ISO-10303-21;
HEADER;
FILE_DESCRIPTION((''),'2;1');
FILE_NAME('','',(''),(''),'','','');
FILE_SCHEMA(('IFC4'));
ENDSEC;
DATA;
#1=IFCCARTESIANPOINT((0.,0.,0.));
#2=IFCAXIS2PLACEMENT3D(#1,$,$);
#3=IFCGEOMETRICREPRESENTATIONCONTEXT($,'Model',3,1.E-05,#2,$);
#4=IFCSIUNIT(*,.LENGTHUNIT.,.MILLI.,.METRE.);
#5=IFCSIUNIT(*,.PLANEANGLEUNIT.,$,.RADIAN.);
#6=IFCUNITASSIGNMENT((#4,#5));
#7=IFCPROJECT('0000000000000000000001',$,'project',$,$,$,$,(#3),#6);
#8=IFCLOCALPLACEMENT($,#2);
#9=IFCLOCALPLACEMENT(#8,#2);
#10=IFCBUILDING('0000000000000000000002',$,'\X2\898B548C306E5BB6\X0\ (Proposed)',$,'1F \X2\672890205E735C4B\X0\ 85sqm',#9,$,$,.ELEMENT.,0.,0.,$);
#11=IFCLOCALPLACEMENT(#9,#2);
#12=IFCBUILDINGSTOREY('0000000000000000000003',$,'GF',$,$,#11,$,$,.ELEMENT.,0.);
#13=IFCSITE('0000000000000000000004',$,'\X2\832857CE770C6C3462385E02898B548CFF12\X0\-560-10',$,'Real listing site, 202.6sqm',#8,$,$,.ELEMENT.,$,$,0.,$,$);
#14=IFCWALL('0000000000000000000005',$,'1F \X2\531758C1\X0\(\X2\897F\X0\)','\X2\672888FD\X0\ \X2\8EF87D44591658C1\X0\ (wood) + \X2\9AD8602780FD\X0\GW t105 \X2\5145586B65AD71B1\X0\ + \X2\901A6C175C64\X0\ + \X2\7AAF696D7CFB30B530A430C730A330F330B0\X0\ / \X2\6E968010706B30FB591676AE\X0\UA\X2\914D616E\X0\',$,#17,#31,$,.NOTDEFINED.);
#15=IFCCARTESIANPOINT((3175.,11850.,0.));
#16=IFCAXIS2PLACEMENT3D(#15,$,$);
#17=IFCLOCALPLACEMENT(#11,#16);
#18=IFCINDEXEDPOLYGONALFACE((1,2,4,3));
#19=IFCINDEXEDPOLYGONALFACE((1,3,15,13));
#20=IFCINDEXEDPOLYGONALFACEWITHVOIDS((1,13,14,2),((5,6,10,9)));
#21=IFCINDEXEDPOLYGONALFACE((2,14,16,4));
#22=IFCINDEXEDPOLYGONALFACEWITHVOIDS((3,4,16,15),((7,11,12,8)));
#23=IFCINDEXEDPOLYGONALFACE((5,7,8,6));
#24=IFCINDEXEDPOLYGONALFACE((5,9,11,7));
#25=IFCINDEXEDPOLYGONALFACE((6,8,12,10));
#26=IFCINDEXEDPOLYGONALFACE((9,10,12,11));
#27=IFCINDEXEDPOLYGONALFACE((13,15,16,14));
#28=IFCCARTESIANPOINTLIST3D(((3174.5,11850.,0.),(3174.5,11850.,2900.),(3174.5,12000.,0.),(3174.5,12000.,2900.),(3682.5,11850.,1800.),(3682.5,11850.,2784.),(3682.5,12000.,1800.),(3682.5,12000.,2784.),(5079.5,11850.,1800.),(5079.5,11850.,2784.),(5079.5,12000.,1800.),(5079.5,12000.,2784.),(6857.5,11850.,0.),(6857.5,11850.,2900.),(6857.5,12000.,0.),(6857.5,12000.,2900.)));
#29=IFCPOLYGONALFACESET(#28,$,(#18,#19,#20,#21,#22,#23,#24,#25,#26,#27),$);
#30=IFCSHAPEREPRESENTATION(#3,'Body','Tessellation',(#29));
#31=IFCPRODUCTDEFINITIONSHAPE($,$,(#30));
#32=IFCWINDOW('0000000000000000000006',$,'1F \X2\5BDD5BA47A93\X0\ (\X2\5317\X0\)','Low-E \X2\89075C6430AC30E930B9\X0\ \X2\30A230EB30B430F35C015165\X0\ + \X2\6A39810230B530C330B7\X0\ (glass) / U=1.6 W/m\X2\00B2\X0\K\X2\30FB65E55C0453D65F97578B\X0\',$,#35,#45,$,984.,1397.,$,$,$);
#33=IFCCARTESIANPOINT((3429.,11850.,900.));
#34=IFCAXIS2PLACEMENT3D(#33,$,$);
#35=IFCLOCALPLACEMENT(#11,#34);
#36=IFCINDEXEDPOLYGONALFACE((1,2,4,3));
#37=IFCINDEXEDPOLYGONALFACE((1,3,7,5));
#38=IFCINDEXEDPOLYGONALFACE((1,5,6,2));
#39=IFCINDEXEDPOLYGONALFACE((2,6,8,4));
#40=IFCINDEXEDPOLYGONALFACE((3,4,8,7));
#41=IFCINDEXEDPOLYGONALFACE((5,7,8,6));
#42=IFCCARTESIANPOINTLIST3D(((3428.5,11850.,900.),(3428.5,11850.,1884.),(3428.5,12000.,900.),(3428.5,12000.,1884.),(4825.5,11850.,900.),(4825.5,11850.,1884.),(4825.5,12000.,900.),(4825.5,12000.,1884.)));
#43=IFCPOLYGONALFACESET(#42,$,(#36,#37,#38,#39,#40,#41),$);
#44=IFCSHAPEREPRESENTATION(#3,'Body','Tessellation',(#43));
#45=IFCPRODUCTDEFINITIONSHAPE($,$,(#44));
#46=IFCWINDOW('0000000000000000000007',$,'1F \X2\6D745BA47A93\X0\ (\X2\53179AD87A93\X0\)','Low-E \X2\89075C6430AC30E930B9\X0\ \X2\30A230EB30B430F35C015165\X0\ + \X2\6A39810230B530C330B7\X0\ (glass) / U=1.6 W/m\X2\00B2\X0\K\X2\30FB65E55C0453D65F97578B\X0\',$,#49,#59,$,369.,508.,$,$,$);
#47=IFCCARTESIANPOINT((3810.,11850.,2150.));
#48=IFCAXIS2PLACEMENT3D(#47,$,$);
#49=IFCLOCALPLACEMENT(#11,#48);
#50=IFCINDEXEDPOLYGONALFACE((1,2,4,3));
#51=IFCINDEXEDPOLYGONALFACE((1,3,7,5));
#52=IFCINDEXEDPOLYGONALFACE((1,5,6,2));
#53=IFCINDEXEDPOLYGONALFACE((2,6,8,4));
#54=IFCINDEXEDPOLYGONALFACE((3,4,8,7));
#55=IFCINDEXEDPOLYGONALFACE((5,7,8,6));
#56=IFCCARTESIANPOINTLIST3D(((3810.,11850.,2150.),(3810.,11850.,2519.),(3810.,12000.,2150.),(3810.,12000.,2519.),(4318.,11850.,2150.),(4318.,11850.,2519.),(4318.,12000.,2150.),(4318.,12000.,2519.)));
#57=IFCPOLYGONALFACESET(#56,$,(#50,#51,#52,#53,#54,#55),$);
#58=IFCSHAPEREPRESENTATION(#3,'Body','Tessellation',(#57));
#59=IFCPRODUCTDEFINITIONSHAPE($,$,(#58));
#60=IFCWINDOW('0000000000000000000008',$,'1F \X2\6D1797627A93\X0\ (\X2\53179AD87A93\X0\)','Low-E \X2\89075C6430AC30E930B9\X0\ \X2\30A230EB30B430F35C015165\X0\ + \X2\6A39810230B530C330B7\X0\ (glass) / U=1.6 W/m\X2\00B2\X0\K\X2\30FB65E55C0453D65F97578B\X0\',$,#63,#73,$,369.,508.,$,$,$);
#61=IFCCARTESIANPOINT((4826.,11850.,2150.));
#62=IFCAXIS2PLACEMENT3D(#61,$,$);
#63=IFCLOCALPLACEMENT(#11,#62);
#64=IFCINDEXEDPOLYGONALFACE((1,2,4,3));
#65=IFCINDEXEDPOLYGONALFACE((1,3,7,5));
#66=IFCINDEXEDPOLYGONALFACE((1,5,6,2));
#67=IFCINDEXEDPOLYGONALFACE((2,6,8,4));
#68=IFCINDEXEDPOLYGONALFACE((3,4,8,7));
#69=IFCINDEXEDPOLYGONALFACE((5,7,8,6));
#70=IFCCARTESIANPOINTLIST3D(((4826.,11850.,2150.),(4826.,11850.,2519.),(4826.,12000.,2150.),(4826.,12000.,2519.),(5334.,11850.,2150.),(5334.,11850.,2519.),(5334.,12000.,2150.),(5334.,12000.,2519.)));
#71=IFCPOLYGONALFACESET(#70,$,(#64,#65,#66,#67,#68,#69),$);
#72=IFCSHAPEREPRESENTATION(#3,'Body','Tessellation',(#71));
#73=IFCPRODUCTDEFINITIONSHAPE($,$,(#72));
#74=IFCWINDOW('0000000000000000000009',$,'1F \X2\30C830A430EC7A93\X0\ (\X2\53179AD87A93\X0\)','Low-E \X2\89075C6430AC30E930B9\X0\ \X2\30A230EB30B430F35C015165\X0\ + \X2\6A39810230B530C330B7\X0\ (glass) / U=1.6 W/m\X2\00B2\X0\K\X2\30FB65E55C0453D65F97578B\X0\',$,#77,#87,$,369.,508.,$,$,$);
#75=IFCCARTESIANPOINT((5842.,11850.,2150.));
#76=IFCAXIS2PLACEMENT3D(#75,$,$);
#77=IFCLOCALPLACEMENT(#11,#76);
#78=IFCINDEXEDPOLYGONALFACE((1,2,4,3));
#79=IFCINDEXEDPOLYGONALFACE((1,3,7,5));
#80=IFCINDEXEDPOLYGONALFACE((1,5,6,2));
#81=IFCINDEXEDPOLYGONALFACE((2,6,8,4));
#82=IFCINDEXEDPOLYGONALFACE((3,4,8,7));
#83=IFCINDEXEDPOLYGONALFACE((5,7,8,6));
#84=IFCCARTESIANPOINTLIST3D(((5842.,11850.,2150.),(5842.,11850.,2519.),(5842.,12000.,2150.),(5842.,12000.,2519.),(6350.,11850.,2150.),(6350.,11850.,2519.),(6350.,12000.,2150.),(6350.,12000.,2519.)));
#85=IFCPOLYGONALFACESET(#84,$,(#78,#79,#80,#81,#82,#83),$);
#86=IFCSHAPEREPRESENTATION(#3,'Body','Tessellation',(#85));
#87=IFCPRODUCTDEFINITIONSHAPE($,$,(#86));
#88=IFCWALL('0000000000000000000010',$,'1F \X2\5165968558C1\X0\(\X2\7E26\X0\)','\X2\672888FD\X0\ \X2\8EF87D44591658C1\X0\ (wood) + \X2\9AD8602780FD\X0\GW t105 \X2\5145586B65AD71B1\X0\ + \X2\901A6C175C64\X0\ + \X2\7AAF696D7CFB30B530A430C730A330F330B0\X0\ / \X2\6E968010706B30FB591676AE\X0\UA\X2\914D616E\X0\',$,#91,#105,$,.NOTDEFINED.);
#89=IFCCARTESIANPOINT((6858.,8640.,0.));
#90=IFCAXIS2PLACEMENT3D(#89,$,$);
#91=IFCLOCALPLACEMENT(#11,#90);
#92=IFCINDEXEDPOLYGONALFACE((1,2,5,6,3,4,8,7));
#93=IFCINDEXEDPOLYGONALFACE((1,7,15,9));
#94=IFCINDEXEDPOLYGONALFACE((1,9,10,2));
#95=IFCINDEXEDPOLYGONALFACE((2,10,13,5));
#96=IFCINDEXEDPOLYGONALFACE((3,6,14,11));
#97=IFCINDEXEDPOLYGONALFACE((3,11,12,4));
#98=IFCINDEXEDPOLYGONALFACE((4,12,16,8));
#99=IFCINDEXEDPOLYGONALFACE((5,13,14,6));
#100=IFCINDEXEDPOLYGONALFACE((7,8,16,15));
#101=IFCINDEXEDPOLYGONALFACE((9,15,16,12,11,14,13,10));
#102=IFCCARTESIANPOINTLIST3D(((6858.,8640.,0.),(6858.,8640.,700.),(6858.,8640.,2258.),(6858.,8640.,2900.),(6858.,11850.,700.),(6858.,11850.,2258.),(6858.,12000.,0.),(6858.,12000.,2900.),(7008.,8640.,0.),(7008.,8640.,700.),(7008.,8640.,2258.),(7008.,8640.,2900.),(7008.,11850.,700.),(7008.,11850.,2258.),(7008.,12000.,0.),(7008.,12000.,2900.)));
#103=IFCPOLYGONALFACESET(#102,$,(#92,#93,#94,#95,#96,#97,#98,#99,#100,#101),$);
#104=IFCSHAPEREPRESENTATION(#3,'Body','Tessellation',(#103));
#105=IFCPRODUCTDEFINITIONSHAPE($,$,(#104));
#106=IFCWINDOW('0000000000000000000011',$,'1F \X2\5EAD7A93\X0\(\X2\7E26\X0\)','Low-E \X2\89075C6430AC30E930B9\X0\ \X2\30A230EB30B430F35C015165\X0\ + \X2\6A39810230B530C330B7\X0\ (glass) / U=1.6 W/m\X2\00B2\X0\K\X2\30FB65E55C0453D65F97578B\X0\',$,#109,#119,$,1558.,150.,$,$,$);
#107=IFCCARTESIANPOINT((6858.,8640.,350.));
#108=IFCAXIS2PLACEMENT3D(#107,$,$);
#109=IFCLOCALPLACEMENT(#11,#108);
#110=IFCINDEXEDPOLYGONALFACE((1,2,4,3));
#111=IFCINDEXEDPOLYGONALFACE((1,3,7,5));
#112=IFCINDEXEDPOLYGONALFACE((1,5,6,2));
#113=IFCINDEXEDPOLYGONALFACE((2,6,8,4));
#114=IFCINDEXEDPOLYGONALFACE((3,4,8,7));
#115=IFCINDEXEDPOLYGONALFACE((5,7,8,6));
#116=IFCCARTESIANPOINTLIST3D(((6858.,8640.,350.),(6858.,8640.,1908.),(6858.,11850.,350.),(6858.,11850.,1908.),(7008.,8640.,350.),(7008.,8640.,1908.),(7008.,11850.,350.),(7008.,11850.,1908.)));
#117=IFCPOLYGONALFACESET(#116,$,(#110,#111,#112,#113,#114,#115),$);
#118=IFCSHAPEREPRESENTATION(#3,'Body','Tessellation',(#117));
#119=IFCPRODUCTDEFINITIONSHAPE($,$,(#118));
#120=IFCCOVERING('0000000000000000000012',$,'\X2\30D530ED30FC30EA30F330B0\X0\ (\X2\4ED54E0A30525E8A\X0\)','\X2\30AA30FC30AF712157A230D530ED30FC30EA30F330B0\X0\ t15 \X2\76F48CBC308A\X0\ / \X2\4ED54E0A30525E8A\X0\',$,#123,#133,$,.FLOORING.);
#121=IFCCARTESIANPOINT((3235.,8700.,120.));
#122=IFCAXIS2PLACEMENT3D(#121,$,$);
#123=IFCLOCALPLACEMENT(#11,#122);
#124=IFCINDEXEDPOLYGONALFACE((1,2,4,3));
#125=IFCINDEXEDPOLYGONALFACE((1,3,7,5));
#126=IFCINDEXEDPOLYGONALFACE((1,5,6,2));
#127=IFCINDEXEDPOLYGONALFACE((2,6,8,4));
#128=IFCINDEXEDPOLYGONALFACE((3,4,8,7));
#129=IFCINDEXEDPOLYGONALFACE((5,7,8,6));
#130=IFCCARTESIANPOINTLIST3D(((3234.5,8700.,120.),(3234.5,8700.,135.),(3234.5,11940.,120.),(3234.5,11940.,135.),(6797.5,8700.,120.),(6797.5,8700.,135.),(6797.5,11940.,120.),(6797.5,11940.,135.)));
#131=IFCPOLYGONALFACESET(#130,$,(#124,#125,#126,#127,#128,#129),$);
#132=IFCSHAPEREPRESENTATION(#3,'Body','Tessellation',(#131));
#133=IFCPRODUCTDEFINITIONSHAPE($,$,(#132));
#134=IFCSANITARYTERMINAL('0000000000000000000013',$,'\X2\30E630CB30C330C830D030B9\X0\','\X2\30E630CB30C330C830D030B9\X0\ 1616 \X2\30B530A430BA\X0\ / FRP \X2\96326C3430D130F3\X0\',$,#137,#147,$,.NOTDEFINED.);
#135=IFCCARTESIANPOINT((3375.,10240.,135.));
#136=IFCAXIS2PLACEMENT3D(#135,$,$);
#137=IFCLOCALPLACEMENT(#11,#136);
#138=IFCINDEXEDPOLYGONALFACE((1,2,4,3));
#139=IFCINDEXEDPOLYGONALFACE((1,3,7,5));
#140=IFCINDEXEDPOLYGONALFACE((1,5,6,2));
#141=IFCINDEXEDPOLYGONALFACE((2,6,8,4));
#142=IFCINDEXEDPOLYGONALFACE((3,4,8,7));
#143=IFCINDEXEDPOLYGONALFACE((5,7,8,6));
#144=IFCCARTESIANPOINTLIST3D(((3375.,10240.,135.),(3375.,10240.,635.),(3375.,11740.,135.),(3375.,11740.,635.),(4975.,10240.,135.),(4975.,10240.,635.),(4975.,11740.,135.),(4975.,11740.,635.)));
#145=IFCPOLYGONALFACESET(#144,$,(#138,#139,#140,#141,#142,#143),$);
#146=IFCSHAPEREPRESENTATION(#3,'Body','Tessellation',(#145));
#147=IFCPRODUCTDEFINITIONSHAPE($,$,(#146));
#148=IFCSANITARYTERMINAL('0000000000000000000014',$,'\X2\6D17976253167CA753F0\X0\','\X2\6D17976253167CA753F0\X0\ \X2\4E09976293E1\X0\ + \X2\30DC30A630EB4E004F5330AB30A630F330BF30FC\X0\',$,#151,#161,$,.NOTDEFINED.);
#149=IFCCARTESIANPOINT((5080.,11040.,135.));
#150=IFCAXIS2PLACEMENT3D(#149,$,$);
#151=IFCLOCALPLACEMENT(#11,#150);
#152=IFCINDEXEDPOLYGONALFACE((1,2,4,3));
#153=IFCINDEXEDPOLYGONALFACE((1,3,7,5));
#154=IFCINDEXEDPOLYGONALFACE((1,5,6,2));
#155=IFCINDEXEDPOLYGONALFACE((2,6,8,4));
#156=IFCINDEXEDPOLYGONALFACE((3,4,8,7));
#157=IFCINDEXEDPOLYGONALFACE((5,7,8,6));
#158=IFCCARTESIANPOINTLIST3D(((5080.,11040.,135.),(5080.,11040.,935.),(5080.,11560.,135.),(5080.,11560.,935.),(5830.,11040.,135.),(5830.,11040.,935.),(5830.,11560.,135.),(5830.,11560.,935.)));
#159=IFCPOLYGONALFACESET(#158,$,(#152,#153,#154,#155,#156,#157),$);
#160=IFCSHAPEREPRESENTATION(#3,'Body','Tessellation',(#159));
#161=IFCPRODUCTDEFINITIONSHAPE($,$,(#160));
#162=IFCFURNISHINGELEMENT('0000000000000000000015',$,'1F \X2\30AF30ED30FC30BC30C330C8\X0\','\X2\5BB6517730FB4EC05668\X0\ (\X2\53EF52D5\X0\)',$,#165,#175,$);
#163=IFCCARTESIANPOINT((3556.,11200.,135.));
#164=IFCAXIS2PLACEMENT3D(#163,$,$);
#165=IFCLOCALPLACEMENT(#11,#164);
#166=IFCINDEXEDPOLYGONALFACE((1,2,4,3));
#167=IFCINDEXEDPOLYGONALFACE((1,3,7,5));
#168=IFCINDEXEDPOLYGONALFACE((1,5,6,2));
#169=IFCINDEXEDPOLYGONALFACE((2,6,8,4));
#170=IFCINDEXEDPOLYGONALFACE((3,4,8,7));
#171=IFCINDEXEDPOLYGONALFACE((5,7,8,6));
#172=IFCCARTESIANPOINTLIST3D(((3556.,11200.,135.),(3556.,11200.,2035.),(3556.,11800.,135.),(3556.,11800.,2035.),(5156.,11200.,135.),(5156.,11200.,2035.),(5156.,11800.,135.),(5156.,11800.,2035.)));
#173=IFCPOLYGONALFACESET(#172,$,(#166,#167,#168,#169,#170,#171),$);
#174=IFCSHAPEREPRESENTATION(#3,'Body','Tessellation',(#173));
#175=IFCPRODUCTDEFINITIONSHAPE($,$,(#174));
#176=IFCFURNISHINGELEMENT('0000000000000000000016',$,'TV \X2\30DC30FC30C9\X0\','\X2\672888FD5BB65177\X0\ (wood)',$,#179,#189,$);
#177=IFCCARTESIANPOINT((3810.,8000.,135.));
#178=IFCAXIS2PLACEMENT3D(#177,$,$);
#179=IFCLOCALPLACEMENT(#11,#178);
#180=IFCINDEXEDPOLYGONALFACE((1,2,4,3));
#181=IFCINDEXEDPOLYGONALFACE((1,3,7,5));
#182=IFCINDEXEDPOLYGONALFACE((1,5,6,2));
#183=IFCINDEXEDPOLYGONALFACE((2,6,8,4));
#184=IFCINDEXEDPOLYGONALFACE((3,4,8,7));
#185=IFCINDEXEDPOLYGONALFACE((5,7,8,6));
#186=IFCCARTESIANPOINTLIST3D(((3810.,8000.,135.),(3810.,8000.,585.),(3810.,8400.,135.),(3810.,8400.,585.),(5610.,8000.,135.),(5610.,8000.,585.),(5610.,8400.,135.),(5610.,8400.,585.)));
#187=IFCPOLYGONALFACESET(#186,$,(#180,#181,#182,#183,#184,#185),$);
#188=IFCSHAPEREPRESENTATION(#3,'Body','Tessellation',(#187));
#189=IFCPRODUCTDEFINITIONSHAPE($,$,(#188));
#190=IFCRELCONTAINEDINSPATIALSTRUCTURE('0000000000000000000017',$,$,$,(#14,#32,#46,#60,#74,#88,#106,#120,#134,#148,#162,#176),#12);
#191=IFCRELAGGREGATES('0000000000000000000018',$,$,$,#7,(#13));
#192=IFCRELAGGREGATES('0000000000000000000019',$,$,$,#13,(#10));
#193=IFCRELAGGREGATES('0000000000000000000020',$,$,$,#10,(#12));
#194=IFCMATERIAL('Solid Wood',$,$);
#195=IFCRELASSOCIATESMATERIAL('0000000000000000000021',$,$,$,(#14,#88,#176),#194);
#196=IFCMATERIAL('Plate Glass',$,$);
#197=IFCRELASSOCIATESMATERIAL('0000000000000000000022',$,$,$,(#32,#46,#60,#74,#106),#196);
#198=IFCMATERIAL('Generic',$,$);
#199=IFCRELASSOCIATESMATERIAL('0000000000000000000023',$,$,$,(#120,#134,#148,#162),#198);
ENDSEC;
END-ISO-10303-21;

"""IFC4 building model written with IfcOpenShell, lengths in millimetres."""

from ifc_helpers import new_model, si_unit, frame, frame_2d, origin, place, context, project, spatial, rectangle, extrude, material, element, fill, save


model = new_model("IFC4")

# Units and contexts
model_context = context("Model", 3, precision=1e-05, world=origin())
ifc_project = project(units=[si_unit("LENGTHUNIT", "METRE", prefix="MILLI"), si_unit("PLANEANGLEUNIT", "RADIAN")], contexts=[model_context])

# Site, building, storey
site_placement = place(None, origin())
site = spatial("IfcSite", under=ifc_project, at=site_placement, Name="茨城県水戸市見和２-560-10", ObjectType="Real listing site, 202.6sqm", CompositionType="ELEMENT", RefElevation=0.0)
building_placement = place(site_placement, origin())
building = spatial("IfcBuilding", under=site, at=building_placement, Name="見和の家 (Proposed)", ObjectType="1F 木造平屋 85sqm", CompositionType="ELEMENT", ElevationOfRefHeight=0.0, ElevationOfTerrain=0.0)
storey_placement = place(building_placement, origin())
storey = spatial("IfcBuildingStorey", under=building, at=storey_placement, Name="GF", CompositionType="ELEMENT", Elevation=0.0)

# Shared definitions
ifc_material_1 = material(Name="Solid Wood")

# Wall, openings, windows
wall_1_placement = place(storey_placement, frame((3175.0, 11850.0, 0.0)))
wall_1 = element("IfcWall", 1, at=wall_1_placement, inside=storey, material=ifc_material_1, Name="1F 北壁(西)", Description="木製 軸組外壁 (wood) + 高性能GW t105 充填断熱 + 通気層 + 窯業系サイディング / 準耐火・外皮UA配慮", PredefinedType="NOTDEFINED", context=model_context, shape_type="SweptSolid", body=[
    extrude(rectangle(XDim=3683.0, YDim=150.0, at=frame_2d((1841.0, 75.0))), frame((3175.0, 11850.0, 0.0)), (0.0, 0.0, 1.0), 2900.0),
])
opening_1_placement = place(storey_placement, frame((3429.0, 11850.0, 900.0)))
opening_1 = element("IfcOpeningElement", 2, at=opening_1_placement, cuts=wall_1, PredefinedType="NOTDEFINED", context=model_context, shape_type="SweptSolid", body=[
    extrude(rectangle(XDim=1397.0, YDim=150.0, at=frame_2d((698.0, 75.0))), frame((3429.0, 11850.0, 900.0)), (0.0, 0.0, 1.0), 984.0),
])
opening_2_placement = place(storey_placement, frame((3810.0, 11850.0, 2150.0)))
opening_2 = element("IfcOpeningElement", 3, at=opening_2_placement, cuts=wall_1, PredefinedType="NOTDEFINED", context=model_context, shape_type="SweptSolid", body=[
    extrude(rectangle(XDim=508.0, YDim=150.0, at=frame_2d((254.0, 75.0))), frame((3810.0, 11850.0, 2150.0)), (0.0, 0.0, 1.0), 369.0),
])
opening_3_placement = place(storey_placement, frame((4826.0, 11850.0, 2150.0)))
opening_3 = element("IfcOpeningElement", 4, at=opening_3_placement, cuts=wall_1, PredefinedType="NOTDEFINED", context=model_context, shape_type="SweptSolid", body=[
    extrude(rectangle(XDim=508.0, YDim=150.0, at=frame_2d((254.0, 75.0))), frame((4826.0, 11850.0, 2150.0)), (0.0, 0.0, 1.0), 369.0),
])
opening_4_placement = place(storey_placement, frame((5842.0, 11850.0, 2150.0)))
opening_4 = element("IfcOpeningElement", 5, at=opening_4_placement, cuts=wall_1, PredefinedType="NOTDEFINED", context=model_context, shape_type="SweptSolid", body=[
    extrude(rectangle(XDim=508.0, YDim=150.0, at=frame_2d((254.0, 75.0))), frame((5842.0, 11850.0, 2150.0)), (0.0, 0.0, 1.0), 369.0),
])
ifc_material_2 = material(Name="Plate Glass")
window_1_placement = place(storey_placement, frame((3429.0, 11850.0, 900.0)))
window_1 = element("IfcWindow", 6, at=window_1_placement, inside=storey, material=ifc_material_2, Name="1F 寝室窓 (北)", Description="Low-E 複層ガラス アルゴン封入 + 樹脂サッシ (glass) / U=1.6 W/m²K・日射取得型", OverallHeight=984.0, OverallWidth=1397.0, context=model_context, shape_type="SweptSolid", body=[
    extrude(rectangle(XDim=1397.0, YDim=150.0, at=frame_2d((698.0, 75.0))), frame((3429.0, 11850.0, 900.0)), (0.0, 0.0, 1.0), 984.0),
])
fill(opening_1, window_1)
window_2_placement = place(storey_placement, frame((3810.0, 11850.0, 2150.0)))
window_2 = element("IfcWindow", 7, at=window_2_placement, inside=storey, material=ifc_material_2, Name="1F 浴室窓 (北高窓)", Description="Low-E 複層ガラス アルゴン封入 + 樹脂サッシ (glass) / U=1.6 W/m²K・日射取得型", OverallHeight=369.0, OverallWidth=508.0, context=model_context, shape_type="SweptSolid", body=[
    extrude(rectangle(XDim=508.0, YDim=150.0, at=frame_2d((254.0, 75.0))), frame((3810.0, 11850.0, 2150.0)), (0.0, 0.0, 1.0), 369.0),
])
fill(opening_2, window_2)
window_3_placement = place(storey_placement, frame((4826.0, 11850.0, 2150.0)))
window_3 = element("IfcWindow", 8, at=window_3_placement, inside=storey, material=ifc_material_2, Name="1F 洗面窓 (北高窓)", Description="Low-E 複層ガラス アルゴン封入 + 樹脂サッシ (glass) / U=1.6 W/m²K・日射取得型", OverallHeight=369.0, OverallWidth=508.0, context=model_context, shape_type="SweptSolid", body=[
    extrude(rectangle(XDim=508.0, YDim=150.0, at=frame_2d((254.0, 75.0))), frame((4826.0, 11850.0, 2150.0)), (0.0, 0.0, 1.0), 369.0),
])
fill(opening_3, window_3)
window_4_placement = place(storey_placement, frame((5842.0, 11850.0, 2150.0)))
window_4 = element("IfcWindow", 9, at=window_4_placement, inside=storey, material=ifc_material_2, Name="1F トイレ窓 (北高窓)", Description="Low-E 複層ガラス アルゴン封入 + 樹脂サッシ (glass) / U=1.6 W/m²K・日射取得型", OverallHeight=369.0, OverallWidth=508.0, context=model_context, shape_type="SweptSolid", body=[
    extrude(rectangle(XDim=508.0, YDim=150.0, at=frame_2d((254.0, 75.0))), frame((5842.0, 11850.0, 2150.0)), (0.0, 0.0, 1.0), 369.0),
])
fill(opening_4, window_4)

# Wall, opening, window
wall_2_placement = place(storey_placement, frame((6858.0, 8640.0, 0.0)))
wall_2 = element("IfcWall", 10, at=wall_2_placement, inside=storey, material=ifc_material_1, Name="1F 入隅壁(縦)", Description="木製 軸組外壁 (wood) + 高性能GW t105 充填断熱 + 通気層 + 窯業系サイディング / 準耐火・外皮UA配慮", PredefinedType="NOTDEFINED", context=model_context, shape_type="SweptSolid", body=[
    extrude(rectangle(XDim=150.0, YDim=3360.0, at=frame_2d((75.0, 1680.0))), frame((6858.0, 8640.0, 0.0)), (0.0, 0.0, 1.0), 2900.0),
])
opening_5_placement = place(storey_placement, frame((6858.0, 8640.0, 350.0)))
opening_5 = element("IfcOpeningElement", 11, at=opening_5_placement, cuts=wall_2, PredefinedType="NOTDEFINED", context=model_context, shape_type="SweptSolid", body=[
    extrude(rectangle(XDim=150.0, YDim=3210.0, at=frame_2d((75.0, 1605.0))), frame((6858.0, 8640.0, 350.0)), (0.0, 0.0, 1.0), 1558.0),
])
window_5_placement = place(storey_placement, frame((6858.0, 8640.0, 350.0)))
window_5 = element("IfcWindow", 12, at=window_5_placement, inside=storey, material=ifc_material_2, Name="1F 庭窓(縦)", Description="Low-E 複層ガラス アルゴン封入 + 樹脂サッシ (glass) / U=1.6 W/m²K・日射取得型", OverallHeight=1558.0, OverallWidth=150.0, context=model_context, shape_type="SweptSolid", body=[
    extrude(rectangle(XDim=150.0, YDim=3210.0, at=frame_2d((75.0, 1605.0))), frame((6858.0, 8640.0, 350.0)), (0.0, 0.0, 1.0), 1558.0),
])
fill(opening_5, window_5)

# Covering
ifc_material_3 = material(Name="Generic")
covering_placement = place(storey_placement, frame((3235.0, 8700.0, 120.0)))
element("IfcCovering", 13, at=covering_placement, inside=storey, material=ifc_material_3, Name="フローリング (仕上げ床)", Description="オーク無垢フローリング t15 直貼り / 仕上げ床", PredefinedType="FLOORING", context=model_context, shape_type="SweptSolid", body=[
    extrude(rectangle(XDim=3563.0, YDim=3240.0, at=frame_2d((1781.0, 1620.0))), frame((3235.0, 8700.0, 120.0)), (0.0, 0.0, 1.0), 15.0),
])

# Sanitary terminals
sanitary_terminal_1_placement = place(storey_placement, frame((3375.0, 10240.0, 135.0)))
element("IfcSanitaryTerminal", 14, at=sanitary_terminal_1_placement, inside=storey, material=ifc_material_3, Name="ユニットバス", Description="ユニットバス 1616 サイズ / FRP 防水パン", PredefinedType="NOTDEFINED", context=model_context, shape_type="SweptSolid", body=[
    extrude(rectangle(XDim=1600.0, YDim=1500.0, at=frame_2d((800.0, 750.0))), frame((3375.0, 10240.0, 135.0)), (0.0, 0.0, 1.0), 500.0),
])
sanitary_terminal_2_placement = place(storey_placement, frame((5080.0, 11040.0, 135.0)))
element("IfcSanitaryTerminal", 15, at=sanitary_terminal_2_placement, inside=storey, material=ifc_material_3, Name="洗面化粧台", Description="洗面化粧台 三面鏡 + ボウル一体カウンター", PredefinedType="NOTDEFINED", context=model_context, shape_type="SweptSolid", body=[
    extrude(rectangle(XDim=750.0, YDim=520.0, at=frame_2d((375.0, 260.0))), frame((5080.0, 11040.0, 135.0)), (0.0, 0.0, 1.0), 800.0),
])

# Furnishing elements
furnishing_1_placement = place(storey_placement, frame((3556.0, 11200.0, 135.0)))
element("IfcFurnishingElement", 16, at=furnishing_1_placement, inside=storey, material=ifc_material_3, Name="1F クローゼット", Description="家具・什器 (可動)", context=model_context, shape_type="SweptSolid", body=[
    extrude(rectangle(XDim=1600.0, YDim=600.0, at=frame_2d((800.0, 300.0))), frame((3556.0, 11200.0, 135.0)), (0.0, 0.0, 1.0), 1900.0),
])
furnishing_2_placement = place(storey_placement, frame((3810.0, 8000.0, 135.0)))
element("IfcFurnishingElement", 17, at=furnishing_2_placement, inside=storey, material=ifc_material_1, Name="TV ボード", Description="木製家具 (wood)", context=model_context, shape_type="SweptSolid", body=[
    extrude(rectangle(XDim=1800.0, YDim=400.0, at=frame_2d((900.0, 200.0))), frame((3810.0, 8000.0, 135.0)), (0.0, 0.0, 1.0), 450.0),
])

save(model, "model.ifc")
